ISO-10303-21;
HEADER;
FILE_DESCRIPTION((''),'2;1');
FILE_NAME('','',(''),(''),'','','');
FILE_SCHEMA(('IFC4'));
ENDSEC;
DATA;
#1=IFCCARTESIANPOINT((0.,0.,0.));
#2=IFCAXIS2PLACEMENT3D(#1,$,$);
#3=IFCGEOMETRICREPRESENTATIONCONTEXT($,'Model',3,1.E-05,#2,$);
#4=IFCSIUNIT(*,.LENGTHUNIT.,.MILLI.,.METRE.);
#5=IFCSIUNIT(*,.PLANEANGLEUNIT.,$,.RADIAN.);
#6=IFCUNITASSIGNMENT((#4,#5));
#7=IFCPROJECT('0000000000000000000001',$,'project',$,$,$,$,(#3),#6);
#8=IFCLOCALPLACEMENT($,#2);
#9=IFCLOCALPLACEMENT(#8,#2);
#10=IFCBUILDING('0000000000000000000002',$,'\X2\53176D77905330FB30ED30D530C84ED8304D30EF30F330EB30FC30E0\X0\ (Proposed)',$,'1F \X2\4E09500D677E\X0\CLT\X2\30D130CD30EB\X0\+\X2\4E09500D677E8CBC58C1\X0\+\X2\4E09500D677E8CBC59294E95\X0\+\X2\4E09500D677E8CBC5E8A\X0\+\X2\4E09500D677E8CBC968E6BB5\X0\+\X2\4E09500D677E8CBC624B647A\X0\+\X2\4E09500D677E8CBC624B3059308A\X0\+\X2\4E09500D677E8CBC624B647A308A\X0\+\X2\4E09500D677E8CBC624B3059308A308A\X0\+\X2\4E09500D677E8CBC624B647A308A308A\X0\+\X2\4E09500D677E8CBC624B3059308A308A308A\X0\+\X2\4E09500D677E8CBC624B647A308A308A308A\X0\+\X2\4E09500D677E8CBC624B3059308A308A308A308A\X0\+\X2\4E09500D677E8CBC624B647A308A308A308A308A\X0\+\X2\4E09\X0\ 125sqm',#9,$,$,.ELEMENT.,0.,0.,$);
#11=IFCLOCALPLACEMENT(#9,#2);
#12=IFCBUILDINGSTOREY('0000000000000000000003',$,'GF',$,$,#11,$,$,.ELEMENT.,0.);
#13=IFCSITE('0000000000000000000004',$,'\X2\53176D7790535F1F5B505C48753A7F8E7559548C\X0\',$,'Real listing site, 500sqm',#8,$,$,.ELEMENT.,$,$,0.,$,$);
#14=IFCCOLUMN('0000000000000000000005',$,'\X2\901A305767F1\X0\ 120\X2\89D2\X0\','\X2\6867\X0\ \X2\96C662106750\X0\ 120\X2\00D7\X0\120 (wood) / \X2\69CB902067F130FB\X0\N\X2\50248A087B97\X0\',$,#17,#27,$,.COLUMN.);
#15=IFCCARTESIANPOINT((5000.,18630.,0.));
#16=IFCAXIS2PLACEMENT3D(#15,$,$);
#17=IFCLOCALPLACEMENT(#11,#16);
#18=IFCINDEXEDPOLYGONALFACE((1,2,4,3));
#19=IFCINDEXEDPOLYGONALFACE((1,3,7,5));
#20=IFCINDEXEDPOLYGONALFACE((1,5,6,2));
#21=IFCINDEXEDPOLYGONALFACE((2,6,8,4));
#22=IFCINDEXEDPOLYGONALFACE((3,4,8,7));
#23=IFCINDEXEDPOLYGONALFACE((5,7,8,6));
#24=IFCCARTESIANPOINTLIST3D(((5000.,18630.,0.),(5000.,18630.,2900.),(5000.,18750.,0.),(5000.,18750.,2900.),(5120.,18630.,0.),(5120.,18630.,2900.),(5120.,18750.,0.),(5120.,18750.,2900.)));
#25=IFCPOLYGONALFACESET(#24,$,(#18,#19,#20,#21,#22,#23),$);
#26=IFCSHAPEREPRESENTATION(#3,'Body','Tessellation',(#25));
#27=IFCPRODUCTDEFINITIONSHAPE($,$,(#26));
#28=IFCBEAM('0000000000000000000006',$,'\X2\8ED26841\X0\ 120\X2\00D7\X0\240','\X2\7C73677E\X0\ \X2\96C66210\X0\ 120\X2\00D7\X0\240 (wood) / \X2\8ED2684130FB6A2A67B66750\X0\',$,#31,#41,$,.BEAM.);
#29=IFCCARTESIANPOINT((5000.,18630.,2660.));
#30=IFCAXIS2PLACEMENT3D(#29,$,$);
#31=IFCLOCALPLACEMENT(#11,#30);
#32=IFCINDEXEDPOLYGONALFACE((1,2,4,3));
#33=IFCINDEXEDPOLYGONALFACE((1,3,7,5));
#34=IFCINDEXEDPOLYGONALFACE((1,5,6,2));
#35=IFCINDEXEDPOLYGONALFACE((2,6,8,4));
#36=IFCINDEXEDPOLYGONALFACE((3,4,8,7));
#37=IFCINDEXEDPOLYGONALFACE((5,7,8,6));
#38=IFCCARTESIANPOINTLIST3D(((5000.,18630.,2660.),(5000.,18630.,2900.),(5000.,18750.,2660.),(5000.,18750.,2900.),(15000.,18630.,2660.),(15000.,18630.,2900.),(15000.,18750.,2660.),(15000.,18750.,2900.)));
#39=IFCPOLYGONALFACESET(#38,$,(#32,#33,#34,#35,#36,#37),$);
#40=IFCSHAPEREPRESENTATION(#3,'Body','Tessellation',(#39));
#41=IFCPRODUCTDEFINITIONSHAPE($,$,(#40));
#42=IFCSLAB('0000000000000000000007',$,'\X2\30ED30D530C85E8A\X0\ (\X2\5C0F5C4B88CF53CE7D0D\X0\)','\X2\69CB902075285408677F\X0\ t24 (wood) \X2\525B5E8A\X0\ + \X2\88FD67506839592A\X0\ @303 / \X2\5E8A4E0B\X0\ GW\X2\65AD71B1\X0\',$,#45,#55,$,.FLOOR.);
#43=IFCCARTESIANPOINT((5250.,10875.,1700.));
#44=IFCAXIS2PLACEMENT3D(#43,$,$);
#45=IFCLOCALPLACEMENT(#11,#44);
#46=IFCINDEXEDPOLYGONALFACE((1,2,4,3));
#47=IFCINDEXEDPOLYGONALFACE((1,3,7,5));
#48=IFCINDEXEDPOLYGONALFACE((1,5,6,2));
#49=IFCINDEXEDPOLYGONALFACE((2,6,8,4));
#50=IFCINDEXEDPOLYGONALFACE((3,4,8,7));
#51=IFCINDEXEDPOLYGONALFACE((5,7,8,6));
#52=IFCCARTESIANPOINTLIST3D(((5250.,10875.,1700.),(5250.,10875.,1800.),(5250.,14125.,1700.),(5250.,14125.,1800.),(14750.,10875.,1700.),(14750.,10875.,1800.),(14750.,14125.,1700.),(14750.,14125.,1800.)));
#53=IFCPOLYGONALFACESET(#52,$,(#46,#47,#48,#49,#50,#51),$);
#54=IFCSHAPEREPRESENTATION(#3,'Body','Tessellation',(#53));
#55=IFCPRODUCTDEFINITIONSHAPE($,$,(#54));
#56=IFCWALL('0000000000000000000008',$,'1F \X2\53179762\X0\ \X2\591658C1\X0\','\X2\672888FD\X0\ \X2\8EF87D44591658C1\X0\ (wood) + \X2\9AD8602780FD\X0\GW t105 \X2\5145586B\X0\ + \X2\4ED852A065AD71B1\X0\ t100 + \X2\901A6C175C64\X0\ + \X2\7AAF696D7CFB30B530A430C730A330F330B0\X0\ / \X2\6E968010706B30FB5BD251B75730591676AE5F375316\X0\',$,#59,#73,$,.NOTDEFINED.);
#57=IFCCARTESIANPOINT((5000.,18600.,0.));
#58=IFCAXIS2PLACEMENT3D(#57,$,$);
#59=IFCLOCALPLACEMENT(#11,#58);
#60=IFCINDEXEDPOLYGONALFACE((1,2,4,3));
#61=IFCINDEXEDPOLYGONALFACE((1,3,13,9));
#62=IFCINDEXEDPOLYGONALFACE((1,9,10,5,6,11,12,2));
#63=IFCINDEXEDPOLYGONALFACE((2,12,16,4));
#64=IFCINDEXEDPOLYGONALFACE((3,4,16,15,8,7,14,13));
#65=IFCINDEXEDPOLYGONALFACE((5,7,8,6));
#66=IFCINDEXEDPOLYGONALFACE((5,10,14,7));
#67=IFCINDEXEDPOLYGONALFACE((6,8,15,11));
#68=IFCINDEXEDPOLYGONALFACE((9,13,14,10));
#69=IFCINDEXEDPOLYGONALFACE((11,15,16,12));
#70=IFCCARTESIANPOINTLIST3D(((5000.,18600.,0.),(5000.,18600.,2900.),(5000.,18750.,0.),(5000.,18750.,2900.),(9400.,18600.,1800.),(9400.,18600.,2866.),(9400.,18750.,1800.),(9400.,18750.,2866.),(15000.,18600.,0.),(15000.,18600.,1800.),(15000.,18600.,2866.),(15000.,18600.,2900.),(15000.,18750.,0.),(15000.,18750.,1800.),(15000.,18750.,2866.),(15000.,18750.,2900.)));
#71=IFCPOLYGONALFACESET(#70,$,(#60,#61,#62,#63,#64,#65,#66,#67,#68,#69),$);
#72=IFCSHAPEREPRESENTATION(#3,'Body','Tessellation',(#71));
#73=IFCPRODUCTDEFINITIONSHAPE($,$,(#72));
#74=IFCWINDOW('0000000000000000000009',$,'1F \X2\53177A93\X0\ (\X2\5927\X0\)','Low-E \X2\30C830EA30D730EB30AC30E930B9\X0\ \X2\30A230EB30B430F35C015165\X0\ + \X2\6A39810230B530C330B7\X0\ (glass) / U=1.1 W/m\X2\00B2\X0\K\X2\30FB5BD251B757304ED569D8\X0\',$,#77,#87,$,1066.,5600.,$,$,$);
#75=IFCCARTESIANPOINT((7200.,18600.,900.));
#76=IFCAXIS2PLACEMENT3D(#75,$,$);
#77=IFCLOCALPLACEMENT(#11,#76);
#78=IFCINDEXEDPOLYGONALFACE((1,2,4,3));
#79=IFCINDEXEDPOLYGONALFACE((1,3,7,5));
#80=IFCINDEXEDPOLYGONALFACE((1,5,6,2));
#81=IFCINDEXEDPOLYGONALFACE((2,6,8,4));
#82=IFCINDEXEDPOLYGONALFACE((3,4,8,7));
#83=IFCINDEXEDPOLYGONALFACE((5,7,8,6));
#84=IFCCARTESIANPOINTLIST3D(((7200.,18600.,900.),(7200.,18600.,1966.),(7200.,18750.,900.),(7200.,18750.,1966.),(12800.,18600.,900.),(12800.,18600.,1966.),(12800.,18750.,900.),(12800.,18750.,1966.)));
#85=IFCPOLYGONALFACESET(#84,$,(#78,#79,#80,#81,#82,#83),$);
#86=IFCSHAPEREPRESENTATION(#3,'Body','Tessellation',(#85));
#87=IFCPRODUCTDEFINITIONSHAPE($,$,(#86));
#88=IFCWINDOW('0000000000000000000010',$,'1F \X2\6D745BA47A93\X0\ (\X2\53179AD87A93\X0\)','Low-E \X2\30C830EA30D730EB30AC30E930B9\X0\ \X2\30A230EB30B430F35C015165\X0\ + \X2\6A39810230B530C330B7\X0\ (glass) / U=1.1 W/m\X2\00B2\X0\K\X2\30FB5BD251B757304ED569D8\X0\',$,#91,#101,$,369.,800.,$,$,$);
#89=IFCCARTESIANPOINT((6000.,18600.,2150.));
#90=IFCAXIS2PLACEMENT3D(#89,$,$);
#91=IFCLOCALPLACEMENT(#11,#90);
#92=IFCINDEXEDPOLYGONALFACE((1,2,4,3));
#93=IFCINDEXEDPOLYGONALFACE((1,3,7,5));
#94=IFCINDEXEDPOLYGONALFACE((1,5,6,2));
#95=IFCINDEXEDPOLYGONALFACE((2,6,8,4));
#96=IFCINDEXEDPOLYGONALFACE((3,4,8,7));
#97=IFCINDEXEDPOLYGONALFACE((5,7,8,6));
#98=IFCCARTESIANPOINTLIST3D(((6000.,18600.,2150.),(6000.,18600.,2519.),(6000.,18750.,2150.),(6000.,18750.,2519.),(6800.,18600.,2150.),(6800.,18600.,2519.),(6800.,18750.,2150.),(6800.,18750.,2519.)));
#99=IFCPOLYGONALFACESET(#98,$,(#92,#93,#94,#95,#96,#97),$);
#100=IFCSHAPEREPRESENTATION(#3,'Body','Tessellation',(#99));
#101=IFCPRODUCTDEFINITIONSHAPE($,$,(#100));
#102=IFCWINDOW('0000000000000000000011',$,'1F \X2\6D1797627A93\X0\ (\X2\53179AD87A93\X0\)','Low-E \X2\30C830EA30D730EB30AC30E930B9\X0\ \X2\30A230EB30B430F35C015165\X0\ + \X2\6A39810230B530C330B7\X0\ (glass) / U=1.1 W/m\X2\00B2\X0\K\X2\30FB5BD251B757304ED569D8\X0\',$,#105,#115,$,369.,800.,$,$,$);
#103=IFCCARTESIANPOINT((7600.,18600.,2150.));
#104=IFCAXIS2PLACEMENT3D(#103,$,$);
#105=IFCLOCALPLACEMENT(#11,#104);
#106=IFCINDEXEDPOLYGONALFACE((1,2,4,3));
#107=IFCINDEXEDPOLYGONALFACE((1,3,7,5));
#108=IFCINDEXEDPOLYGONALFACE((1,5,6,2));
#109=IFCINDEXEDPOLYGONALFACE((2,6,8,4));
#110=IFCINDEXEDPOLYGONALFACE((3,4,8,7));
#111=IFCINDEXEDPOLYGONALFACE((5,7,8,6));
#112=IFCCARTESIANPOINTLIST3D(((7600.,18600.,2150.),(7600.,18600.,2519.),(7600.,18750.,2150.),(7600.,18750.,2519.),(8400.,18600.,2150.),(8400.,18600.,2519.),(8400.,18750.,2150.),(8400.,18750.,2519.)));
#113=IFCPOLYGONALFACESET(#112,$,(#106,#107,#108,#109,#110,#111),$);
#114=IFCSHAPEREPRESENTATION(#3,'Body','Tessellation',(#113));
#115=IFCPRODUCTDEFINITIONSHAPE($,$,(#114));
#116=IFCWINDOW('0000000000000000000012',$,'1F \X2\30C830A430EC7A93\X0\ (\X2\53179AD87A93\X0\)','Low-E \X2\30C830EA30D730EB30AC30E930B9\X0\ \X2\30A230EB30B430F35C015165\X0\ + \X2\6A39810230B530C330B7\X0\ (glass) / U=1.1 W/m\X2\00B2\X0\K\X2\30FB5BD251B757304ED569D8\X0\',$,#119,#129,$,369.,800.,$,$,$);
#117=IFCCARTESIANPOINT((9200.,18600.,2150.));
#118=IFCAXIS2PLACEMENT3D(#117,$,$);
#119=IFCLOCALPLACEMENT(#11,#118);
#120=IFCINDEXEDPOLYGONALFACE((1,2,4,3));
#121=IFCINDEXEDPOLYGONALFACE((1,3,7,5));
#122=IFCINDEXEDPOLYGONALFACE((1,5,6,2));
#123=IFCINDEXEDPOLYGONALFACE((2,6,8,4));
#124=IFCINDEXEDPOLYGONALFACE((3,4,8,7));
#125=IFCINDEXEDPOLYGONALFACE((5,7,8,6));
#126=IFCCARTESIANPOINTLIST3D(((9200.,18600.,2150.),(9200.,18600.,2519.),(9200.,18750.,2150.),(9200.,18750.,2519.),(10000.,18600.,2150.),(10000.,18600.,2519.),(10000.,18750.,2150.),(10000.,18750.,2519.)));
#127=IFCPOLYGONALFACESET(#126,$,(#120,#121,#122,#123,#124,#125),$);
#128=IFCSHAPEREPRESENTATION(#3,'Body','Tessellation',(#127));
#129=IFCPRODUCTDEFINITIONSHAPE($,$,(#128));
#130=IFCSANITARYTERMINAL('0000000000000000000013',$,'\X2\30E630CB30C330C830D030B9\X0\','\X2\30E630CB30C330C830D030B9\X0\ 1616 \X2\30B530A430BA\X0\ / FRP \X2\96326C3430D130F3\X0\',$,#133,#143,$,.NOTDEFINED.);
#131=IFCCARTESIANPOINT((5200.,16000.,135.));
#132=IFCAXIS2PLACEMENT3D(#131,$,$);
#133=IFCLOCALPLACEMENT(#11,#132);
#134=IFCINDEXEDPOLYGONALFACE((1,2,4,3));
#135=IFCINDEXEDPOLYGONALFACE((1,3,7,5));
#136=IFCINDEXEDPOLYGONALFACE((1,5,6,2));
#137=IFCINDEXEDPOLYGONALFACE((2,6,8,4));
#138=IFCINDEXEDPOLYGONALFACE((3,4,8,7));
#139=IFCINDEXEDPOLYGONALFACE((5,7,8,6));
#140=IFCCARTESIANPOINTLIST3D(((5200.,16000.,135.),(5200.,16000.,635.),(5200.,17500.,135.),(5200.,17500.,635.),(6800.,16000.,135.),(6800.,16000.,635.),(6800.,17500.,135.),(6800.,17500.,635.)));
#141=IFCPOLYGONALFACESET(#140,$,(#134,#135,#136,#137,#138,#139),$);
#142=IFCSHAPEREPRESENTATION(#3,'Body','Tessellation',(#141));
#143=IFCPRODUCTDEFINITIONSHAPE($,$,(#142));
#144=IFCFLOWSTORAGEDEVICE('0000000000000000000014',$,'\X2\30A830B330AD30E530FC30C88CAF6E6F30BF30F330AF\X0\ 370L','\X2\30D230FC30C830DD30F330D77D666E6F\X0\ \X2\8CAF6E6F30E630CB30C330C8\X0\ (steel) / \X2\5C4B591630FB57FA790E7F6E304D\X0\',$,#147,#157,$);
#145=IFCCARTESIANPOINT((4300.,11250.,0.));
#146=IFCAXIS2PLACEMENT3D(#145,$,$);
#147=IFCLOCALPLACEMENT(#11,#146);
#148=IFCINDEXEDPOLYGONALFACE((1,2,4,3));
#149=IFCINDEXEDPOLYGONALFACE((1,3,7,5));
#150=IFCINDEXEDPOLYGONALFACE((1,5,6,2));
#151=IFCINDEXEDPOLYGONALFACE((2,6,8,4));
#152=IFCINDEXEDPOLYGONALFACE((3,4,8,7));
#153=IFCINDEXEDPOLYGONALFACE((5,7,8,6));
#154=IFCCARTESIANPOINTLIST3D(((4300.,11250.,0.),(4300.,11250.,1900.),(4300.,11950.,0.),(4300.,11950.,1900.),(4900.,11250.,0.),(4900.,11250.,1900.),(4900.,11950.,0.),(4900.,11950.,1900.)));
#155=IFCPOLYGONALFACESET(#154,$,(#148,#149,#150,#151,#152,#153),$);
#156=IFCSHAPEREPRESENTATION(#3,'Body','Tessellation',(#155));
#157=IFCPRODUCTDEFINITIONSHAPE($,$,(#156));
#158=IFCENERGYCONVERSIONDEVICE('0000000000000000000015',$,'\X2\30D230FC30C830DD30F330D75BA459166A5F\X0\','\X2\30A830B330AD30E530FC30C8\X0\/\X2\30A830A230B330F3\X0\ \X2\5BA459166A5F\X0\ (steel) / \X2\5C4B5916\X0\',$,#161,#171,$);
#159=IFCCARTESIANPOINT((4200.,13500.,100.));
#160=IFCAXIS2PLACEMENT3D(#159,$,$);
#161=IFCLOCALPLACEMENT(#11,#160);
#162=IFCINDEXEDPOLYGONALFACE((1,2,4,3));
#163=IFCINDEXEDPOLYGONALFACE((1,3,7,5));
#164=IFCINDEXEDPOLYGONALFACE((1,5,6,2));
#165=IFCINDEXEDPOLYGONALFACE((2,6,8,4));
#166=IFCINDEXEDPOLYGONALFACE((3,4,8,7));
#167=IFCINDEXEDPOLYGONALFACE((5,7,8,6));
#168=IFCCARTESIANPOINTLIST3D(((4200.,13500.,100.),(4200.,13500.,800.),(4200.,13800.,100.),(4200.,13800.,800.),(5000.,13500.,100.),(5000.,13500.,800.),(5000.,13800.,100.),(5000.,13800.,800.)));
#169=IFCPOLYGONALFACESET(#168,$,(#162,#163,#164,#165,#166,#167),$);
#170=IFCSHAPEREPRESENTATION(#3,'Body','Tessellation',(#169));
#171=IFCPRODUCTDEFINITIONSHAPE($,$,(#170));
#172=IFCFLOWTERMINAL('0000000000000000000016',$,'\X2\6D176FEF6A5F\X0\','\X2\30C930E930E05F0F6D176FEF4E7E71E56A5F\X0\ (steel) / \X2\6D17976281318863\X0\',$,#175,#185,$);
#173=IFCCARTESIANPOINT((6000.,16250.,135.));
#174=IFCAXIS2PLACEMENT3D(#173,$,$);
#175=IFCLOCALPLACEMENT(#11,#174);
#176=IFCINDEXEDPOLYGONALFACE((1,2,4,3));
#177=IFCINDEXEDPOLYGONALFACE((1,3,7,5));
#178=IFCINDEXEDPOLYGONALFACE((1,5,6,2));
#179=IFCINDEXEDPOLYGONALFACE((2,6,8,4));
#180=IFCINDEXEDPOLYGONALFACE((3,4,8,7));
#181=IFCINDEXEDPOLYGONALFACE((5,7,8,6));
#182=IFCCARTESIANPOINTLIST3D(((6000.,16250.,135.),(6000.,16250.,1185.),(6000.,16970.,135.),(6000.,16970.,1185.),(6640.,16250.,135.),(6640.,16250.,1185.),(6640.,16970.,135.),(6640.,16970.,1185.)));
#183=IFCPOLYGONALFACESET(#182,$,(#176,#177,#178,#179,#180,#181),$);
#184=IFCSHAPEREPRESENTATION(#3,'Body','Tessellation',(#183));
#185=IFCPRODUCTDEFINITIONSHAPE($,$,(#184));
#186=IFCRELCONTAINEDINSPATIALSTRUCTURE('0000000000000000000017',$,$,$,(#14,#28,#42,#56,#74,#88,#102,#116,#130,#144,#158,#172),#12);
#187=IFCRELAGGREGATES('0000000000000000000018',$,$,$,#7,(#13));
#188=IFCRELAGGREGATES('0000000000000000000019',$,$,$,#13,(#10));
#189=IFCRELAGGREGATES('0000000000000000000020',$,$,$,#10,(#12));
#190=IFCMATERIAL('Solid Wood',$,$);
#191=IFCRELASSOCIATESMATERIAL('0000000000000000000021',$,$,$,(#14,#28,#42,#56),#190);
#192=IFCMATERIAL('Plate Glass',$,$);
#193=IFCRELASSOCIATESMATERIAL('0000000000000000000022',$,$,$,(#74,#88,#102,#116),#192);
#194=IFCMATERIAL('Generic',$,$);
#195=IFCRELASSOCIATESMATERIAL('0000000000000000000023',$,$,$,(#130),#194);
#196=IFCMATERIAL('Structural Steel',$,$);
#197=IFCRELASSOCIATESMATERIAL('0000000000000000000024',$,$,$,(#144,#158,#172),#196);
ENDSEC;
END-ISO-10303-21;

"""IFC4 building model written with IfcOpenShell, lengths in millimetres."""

from ifc_helpers import new_model, si_unit, frame, frame_2d, origin, place, context, project, spatial, rectangle, extrude, material, element, fill, save


model = new_model("IFC4")

# Units and contexts
model_context = context("Model", 3, precision=1e-05, world=origin())
ifc_project = project(units=[si_unit("LENGTHUNIT", "METRE", prefix="MILLI"), si_unit("PLANEANGLEUNIT", "RADIAN")], contexts=[model_context])

# Site, building, storey
site_placement = place(None, origin())
site = spatial("IfcSite", under=ifc_project, at=site_placement, Name="北海道弟子屈町美留和", ObjectType="Real listing site, 500sqm", CompositionType="ELEMENT", RefElevation=0.0)
building_placement = place(site_placement, origin())
building = spatial("IfcBuilding", under=site, at=building_placement, Name="北海道・ロフト付きワンルーム (Proposed)", ObjectType="1F 三倍松CLTパネル+三倍松貼壁+三倍松貼天井+三倍松貼床+三倍松貼階段+三倍松貼手摺+三倍松貼手すり+三倍松貼手摺り+三倍松貼手すりり+三倍松貼手摺りり+三倍松貼手すりりり+三倍松貼手摺りりり+三倍松貼手すりりりり+三倍松貼手摺りりりり+三 125sqm", CompositionType="ELEMENT", ElevationOfRefHeight=0.0, ElevationOfTerrain=0.0)
storey_placement = place(building_placement, origin())
storey = spatial("IfcBuildingStorey", under=building, at=storey_placement, Name="GF", CompositionType="ELEMENT", Elevation=0.0)

# Column
ifc_material_1 = material(Name="Solid Wood")
column_1_placement = place(storey_placement, frame((5000.0, 18630.0, 0.0)))
element("IfcColumn", 1, at=column_1_placement, inside=storey, material=ifc_material_1, Name="通し柱 120角", Description="桧 集成材 120×120 (wood) / 構造柱・N値計算", PredefinedType="COLUMN", context=model_context, shape_type="SweptSolid", body=[
    extrude(rectangle(XDim=120.0, YDim=120.0, at=frame_2d((60.0, 60.0))), frame((5000.0, 18630.0, 0.0)), (0.0, 0.0, 1.0), 2900.0),
])

# Beam
beam_1_placement = place(storey_placement, frame((5000.0, 18630.0, 2660.0)))
element("IfcBeam", 2, at=beam_1_placement, inside=storey, material=ifc_material_1, Name="軒桁 120×240", Description="米松 集成 120×240 (wood) / 軒桁・横架材", PredefinedType="BEAM", context=model_context, shape_type="SweptSolid", body=[
    extrude(rectangle(XDim=10000.0, YDim=120.0, at=frame_2d((5000.0, 60.0))), frame((5000.0, 18630.0, 2660.0)), (0.0, 0.0, 1.0), 240.0),
])

# Slab
slab_placement = place(storey_placement, frame((5250.0, 10875.0, 1700.0)))
element("IfcSlab", 3, at=slab_placement, inside=storey, material=ifc_material_1, Name="ロフト床 (小屋裏収納)", Description="構造用合板 t24 (wood) 剛床 + 製材根太 @303 / 床下 GW断熱", PredefinedType="FLOOR", context=model_context, shape_type="SweptSolid", body=[
    extrude(rectangle(XDim=9500.0, YDim=3250.0, at=frame_2d((4750.0, 1625.0))), frame((5250.0, 10875.0, 1700.0)), (0.0, 0.0, 1.0), 100.0),
])

# Wall, openings, windows
wall_1_placement = place(storey_placement, frame((5000.0, 18600.0, 0.0)))
wall_1 = element("IfcWall", 4, at=wall_1_placement, inside=storey, material=ifc_material_1, Name="1F 北面 外壁", Description="木製 軸組外壁 (wood) + 高性能GW t105 充填 + 付加断熱 t100 + 通気層 + 窯業系サイディング / 準耐火・寒冷地外皮強化", PredefinedType="NOTDEFINED", context=model_context, shape_type="SweptSolid", body=[
    extrude(rectangle(XDim=10000.0, YDim=150.0, at=frame_2d((5000.0, 75.0))), frame((5000.0, 18600.0, 0.0)), (0.0, 0.0, 1.0), 2900.0),
])
opening_1_placement = place(storey_placement, frame((7200.0, 18600.0, 900.0)))
opening_1 = element("IfcOpeningElement", 5, at=opening_1_placement, cuts=wall_1, PredefinedType="NOTDEFINED", context=model_context, shape_type="SweptSolid", body=[
    extrude(rectangle(XDim=5600.0, YDim=150.0, at=frame_2d((2800.0, 75.0))), frame((7200.0, 18600.0, 900.0)), (0.0, 0.0, 1.0), 1066.0),
])
opening_2_placement = place(storey_placement, frame((6000.0, 18600.0, 2150.0)))
opening_2 = element("IfcOpeningElement", 6, at=opening_2_placement, cuts=wall_1, PredefinedType="NOTDEFINED", context=model_context, shape_type="SweptSolid", body=[
    extrude(rectangle(XDim=800.0, YDim=150.0, at=frame_2d((400.0, 75.0))), frame((6000.0, 18600.0, 2150.0)), (0.0, 0.0, 1.0), 369.0),
])
opening_3_placement = place(storey_placement, frame((7600.0, 18600.0, 2150.0)))
opening_3 = element("IfcOpeningElement", 7, at=opening_3_placement, cuts=wall_1, PredefinedType="NOTDEFINED", context=model_context, shape_type="SweptSolid", body=[
    extrude(rectangle(XDim=800.0, YDim=150.0, at=frame_2d((400.0, 75.0))), frame((7600.0, 18600.0, 2150.0)), (0.0, 0.0, 1.0), 369.0),
])
opening_4_placement = place(storey_placement, frame((9200.0, 18600.0, 2150.0)))
opening_4 = element("IfcOpeningElement", 8, at=opening_4_placement, cuts=wall_1, PredefinedType="NOTDEFINED", context=model_context, shape_type="SweptSolid", body=[
    extrude(rectangle(XDim=800.0, YDim=150.0, at=frame_2d((400.0, 75.0))), frame((9200.0, 18600.0, 2150.0)), (0.0, 0.0, 1.0), 369.0),
])
ifc_material_2 = material(Name="Plate Glass")
window_1_placement = place(storey_placement, frame((7200.0, 18600.0, 900.0)))
window_1 = element("IfcWindow", 9, at=window_1_placement, inside=storey, material=ifc_material_2, Name="1F 北窓 (大)", Description="Low-E トリプルガラス アルゴン封入 + 樹脂サッシ (glass) / U=1.1 W/m²K・寒冷地仕様", OverallHeight=1066.0, OverallWidth=5600.0, context=model_context, shape_type="SweptSolid", body=[
    extrude(rectangle(XDim=5600.0, YDim=150.0, at=frame_2d((2800.0, 75.0))), frame((7200.0, 18600.0, 900.0)), (0.0, 0.0, 1.0), 1066.0),
])
fill(opening_1, window_1)
window_2_placement = place(storey_placement, frame((6000.0, 18600.0, 2150.0)))
window_2 = element("IfcWindow", 10, at=window_2_placement, inside=storey, material=ifc_material_2, Name="1F 浴室窓 (北高窓)", Description="Low-E トリプルガラス アルゴン封入 + 樹脂サッシ (glass) / U=1.1 W/m²K・寒冷地仕様", OverallHeight=369.0, OverallWidth=800.0, context=model_context, shape_type="SweptSolid", body=[
    extrude(rectangle(XDim=800.0, YDim=150.0, at=frame_2d((400.0, 75.0))), frame((6000.0, 18600.0, 2150.0)), (0.0, 0.0, 1.0), 369.0),
])
fill(opening_2, window_2)
window_3_placement = place(storey_placement, frame((7600.0, 18600.0, 2150.0)))
window_3 = element("IfcWindow", 11, at=window_3_placement, inside=storey, material=ifc_material_2, Name="1F 洗面窓 (北高窓)", Description="Low-E トリプルガラス アルゴン封入 + 樹脂サッシ (glass) / U=1.1 W/m²K・寒冷地仕様", OverallHeight=369.0, OverallWidth=800.0, context=model_context, shape_type="SweptSolid", body=[
    extrude(rectangle(XDim=800.0, YDim=150.0, at=frame_2d((400.0, 75.0))), frame((7600.0, 18600.0, 2150.0)), (0.0, 0.0, 1.0), 369.0),
])
fill(opening_3, window_3)
window_4_placement = place(storey_placement, frame((9200.0, 18600.0, 2150.0)))
window_4 = element("IfcWindow", 12, at=window_4_placement, inside=storey, material=ifc_material_2, Name="1F トイレ窓 (北高窓)", Description="Low-E トリプルガラス アルゴン封入 + 樹脂サッシ (glass) / U=1.1 W/m²K・寒冷地仕様", OverallHeight=369.0, OverallWidth=800.0, context=model_context, shape_type="SweptSolid", body=[
    extrude(rectangle(XDim=800.0, YDim=150.0, at=frame_2d((400.0, 75.0))), frame((9200.0, 18600.0, 2150.0)), (0.0, 0.0, 1.0), 369.0),
])
fill(opening_4, window_4)

# Sanitary terminal
ifc_material_3 = material(Name="Generic")
sanitary_terminal_placement = place(storey_placement, frame((5200.0, 16000.0, 135.0)))
element("IfcSanitaryTerminal", 13, at=sanitary_terminal_placement, inside=storey, material=ifc_material_3, Name="ユニットバス", Description="ユニットバス 1616 サイズ / FRP 防水パン", PredefinedType="NOTDEFINED", context=model_context, shape_type="SweptSolid", body=[
    extrude(rectangle(XDim=1600.0, YDim=1500.0, at=frame_2d((800.0, 750.0))), frame((5200.0, 16000.0, 135.0)), (0.0, 0.0, 1.0), 500.0),
])

# Flow storage device
ifc_material_4 = material(Name="Structural Steel")
flow_storage_device_placement = place(storey_placement, frame((4300.0, 11250.0, 0.0)))
element("IfcFlowStorageDevice", 14, at=flow_storage_device_placement, inside=storey, material=ifc_material_4, Name="エコキュート貯湯タンク 370L", Description="ヒートポンプ給湯 貯湯ユニット (steel) / 屋外・基礎置き", context=model_context, shape_type="SweptSolid", body=[
    extrude(rectangle(XDim=600.0, YDim=700.0, at=frame_2d((300.0, 350.0))), frame((4300.0, 11250.0, 0.0)), (0.0, 0.0, 1.0), 1900.0),
])

# Energy conversion device
energy_conversion_device_placement = place(storey_placement, frame((4200.0, 13500.0, 100.0)))
element("IfcEnergyConversionDevice", 15, at=energy_conversion_device_placement, inside=storey, material=ifc_material_4, Name="ヒートポンプ室外機", Description="エコキュート/エアコン 室外機 (steel) / 屋外", context=model_context, shape_type="SweptSolid", body=[
    extrude(rectangle(XDim=800.0, YDim=300.0, at=frame_2d((400.0, 150.0))), frame((4200.0, 13500.0, 100.0)), (0.0, 0.0, 1.0), 700.0),
])

# Flow terminal
flow_terminal_placement = place(storey_placement, frame((6000.0, 16250.0, 135.0)))
element("IfcFlowTerminal", 16, at=flow_terminal_placement, inside=storey, material=ifc_material_4, Name="洗濯機", Description="ドラム式洗濯乾燥機 (steel) / 洗面脱衣", context=model_context, shape_type="SweptSolid", body=[
    extrude(rectangle(XDim=640.0, YDim=720.0, at=frame_2d((320.0, 360.0))), frame((6000.0, 16250.0, 135.0)), (0.0, 0.0, 1.0), 1050.0),
])

save(model, "model.ifc")
